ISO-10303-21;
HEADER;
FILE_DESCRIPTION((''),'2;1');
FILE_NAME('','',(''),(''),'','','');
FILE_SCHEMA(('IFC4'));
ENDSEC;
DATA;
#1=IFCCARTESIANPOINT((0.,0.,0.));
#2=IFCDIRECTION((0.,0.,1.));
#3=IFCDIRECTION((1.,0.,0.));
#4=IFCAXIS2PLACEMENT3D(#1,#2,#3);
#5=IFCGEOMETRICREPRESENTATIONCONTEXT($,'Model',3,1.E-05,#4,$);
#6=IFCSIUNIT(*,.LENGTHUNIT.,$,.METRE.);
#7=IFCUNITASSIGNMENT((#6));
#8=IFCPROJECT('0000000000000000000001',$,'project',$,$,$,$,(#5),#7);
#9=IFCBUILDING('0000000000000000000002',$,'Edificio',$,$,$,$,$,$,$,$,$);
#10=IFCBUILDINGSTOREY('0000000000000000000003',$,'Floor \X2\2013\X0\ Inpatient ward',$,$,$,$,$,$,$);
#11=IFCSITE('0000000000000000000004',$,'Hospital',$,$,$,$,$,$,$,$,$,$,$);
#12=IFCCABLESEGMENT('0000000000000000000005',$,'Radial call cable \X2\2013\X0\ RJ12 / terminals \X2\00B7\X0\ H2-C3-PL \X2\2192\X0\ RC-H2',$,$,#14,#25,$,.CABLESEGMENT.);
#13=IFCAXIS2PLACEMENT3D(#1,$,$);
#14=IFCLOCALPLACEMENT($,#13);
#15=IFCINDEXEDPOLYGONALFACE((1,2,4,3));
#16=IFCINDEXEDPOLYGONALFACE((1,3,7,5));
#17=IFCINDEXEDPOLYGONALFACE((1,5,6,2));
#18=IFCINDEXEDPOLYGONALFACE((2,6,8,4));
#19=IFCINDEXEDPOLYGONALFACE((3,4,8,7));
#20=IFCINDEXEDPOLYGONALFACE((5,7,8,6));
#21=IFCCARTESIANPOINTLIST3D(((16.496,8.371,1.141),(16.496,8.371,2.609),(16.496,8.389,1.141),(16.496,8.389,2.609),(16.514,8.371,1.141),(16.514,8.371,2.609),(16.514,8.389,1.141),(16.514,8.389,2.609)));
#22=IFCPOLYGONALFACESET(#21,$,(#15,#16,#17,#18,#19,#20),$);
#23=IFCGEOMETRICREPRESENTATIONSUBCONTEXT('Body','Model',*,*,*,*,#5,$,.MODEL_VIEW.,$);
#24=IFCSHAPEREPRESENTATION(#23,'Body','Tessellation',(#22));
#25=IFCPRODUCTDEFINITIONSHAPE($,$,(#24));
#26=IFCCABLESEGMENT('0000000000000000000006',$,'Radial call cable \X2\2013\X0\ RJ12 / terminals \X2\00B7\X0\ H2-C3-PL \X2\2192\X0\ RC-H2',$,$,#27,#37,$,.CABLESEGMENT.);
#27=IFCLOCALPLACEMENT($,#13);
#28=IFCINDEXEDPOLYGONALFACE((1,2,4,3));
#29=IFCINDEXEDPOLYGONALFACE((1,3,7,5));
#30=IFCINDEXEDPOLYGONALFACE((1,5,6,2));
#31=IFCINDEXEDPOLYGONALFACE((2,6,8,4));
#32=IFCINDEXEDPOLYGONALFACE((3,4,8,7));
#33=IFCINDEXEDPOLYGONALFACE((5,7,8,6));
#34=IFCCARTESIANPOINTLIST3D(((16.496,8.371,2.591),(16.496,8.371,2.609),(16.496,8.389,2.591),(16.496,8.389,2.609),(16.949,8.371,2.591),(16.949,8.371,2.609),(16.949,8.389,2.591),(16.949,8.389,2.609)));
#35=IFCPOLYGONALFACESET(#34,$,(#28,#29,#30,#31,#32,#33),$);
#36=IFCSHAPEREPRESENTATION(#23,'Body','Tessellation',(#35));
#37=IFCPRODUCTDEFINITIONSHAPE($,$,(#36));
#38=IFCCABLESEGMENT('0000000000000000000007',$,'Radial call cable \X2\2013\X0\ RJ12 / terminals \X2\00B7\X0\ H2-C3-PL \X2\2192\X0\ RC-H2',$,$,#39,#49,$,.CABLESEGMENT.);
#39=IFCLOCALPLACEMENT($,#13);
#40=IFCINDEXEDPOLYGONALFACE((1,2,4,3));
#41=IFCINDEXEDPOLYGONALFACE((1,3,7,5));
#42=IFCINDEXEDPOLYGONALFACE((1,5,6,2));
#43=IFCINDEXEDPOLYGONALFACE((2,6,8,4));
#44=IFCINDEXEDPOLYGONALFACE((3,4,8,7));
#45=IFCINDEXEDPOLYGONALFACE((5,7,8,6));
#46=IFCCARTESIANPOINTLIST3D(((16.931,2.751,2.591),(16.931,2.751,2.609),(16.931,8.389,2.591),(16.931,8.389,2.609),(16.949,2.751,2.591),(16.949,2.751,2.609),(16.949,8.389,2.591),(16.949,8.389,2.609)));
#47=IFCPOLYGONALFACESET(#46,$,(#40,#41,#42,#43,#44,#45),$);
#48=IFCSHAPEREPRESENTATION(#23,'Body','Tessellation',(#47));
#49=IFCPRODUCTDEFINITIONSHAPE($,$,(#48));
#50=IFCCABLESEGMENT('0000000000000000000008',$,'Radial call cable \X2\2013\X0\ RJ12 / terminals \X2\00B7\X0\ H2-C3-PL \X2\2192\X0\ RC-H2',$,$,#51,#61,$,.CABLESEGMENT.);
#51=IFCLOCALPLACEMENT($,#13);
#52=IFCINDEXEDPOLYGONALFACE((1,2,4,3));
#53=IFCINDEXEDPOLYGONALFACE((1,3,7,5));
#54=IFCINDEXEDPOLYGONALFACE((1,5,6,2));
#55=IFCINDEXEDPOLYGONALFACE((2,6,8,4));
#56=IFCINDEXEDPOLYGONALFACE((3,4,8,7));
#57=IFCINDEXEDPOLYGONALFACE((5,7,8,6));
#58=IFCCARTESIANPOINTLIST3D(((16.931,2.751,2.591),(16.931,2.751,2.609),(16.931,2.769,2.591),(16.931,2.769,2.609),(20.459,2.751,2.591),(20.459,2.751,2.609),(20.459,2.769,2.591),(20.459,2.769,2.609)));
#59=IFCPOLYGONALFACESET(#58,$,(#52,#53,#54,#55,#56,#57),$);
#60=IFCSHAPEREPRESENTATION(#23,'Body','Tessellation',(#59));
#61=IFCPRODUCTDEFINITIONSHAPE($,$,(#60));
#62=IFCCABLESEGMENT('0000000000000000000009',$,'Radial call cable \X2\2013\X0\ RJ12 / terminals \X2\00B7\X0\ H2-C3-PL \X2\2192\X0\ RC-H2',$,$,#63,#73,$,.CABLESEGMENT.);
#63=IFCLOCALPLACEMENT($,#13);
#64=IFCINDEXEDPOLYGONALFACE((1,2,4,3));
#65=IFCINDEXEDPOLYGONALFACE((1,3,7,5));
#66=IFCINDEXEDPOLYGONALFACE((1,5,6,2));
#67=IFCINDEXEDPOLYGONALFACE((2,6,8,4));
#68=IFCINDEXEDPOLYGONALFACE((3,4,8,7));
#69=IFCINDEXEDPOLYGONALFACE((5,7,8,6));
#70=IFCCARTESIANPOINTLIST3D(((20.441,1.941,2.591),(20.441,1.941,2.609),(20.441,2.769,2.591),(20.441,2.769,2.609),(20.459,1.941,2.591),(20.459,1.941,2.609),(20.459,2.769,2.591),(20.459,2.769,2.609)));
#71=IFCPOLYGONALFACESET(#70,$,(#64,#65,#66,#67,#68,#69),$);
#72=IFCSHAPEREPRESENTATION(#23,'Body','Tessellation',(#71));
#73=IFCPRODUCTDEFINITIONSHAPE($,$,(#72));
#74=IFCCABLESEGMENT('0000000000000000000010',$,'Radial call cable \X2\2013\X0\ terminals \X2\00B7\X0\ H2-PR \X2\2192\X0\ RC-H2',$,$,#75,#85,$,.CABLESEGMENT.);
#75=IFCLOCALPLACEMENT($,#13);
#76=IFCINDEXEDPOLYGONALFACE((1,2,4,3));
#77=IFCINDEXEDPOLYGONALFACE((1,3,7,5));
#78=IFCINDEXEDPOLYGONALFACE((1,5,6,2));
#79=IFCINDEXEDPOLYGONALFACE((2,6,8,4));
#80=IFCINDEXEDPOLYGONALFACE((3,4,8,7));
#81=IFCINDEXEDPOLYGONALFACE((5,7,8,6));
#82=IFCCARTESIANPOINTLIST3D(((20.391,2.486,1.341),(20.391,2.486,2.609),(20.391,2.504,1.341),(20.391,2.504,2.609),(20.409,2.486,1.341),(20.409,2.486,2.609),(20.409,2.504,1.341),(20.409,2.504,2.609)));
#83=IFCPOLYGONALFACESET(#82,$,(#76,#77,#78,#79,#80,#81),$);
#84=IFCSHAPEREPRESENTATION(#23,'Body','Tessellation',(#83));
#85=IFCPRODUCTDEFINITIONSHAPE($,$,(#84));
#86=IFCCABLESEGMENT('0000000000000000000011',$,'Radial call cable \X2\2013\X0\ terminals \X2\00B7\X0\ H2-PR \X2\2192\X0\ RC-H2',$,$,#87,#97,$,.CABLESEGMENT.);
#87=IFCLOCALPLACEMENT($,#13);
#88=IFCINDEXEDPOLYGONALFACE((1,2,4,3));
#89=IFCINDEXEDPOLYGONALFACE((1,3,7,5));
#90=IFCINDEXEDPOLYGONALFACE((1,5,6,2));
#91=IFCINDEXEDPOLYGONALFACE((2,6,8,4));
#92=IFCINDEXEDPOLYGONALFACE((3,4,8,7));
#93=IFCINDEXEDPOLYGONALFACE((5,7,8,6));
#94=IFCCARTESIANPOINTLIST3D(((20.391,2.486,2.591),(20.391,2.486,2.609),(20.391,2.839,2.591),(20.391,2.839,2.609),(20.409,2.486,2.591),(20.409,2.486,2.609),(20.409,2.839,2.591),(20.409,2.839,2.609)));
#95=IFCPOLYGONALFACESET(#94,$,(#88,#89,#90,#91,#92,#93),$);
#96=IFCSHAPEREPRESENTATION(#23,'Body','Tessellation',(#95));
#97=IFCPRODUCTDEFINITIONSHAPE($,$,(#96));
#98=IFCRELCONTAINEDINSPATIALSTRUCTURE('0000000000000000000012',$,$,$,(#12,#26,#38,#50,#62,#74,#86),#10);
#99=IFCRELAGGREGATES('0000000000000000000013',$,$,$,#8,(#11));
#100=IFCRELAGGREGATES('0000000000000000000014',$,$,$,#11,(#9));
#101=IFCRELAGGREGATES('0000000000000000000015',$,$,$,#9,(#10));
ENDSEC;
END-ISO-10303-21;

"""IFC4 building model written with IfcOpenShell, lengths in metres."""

from ifc_helpers import new_model, si_unit, frame, origin_with_axes, context, subcontext, project, spatial, line, indexed_curve, outline, extrude, element, save


model = new_model("IFC4")

# Units and contexts
model_context = context("Model", 3, precision=1e-05, world=origin_with_axes())
body_context = subcontext(model_context, "Body", "Model", "MODEL_VIEW")
ifc_project = project(units=[si_unit("LENGTHUNIT", "METRE")], contexts=[model_context])

# Site, building, storey
site = spatial("IfcSite", under=ifc_project, Name="Hospital")
building = spatial("IfcBuilding", under=site, Name="Edificio")
storey = spatial("IfcBuildingStorey", under=building, Name="Floor – Inpatient ward")

# Cable segments
element("IfcCableSegment", 1, inside=storey, Name="Radial call cable – RJ12 / terminals · H2-C3-PL → RC-H2", PredefinedType="CABLESEGMENT", context=body_context, shape_type="SweptSolid", body=[
    extrude(outline(indexed_curve([(0.0, 0.0), (0.018, 0.0), (0.018, 0.018), (0.0, 0.018)], segments=[line(1, 2, 3, 4, 1)])), frame((16.496, 8.371, 1.141), z_axis=(0.0, 0.0, 1.0), x_axis=(1.0, 0.0, 0.0)), (0.0, 0.0, 1.0), 1.468),
])
element("IfcCableSegment", 2, inside=storey, Name="Radial call cable – RJ12 / terminals · H2-C3-PL → RC-H2", PredefinedType="CABLESEGMENT", context=body_context, shape_type="SweptSolid", body=[
    extrude(outline(indexed_curve([(0.0, 0.0), (0.453, 0.0), (0.453, 0.018), (0.0, 0.018)], segments=[line(1, 2, 3, 4, 1)])), frame((16.496, 8.371, 2.591), z_axis=(0.0, 0.0, 1.0), x_axis=(1.0, 0.0, 0.0)), (0.0, 0.0, 1.0), 0.018),
])
element("IfcCableSegment", 3, inside=storey, Name="Radial call cable – RJ12 / terminals · H2-C3-PL → RC-H2", PredefinedType="CABLESEGMENT", context=body_context, shape_type="SweptSolid", body=[
    extrude(outline(indexed_curve([(0.0, 0.0), (0.018, 0.0), (0.018, 5.638), (0.0, 5.638)], segments=[line(1, 2, 3, 4, 1)])), frame((16.931, 2.751, 2.591), z_axis=(0.0, 0.0, 1.0), x_axis=(1.0, 0.0, 0.0)), (0.0, 0.0, 1.0), 0.018),
])
element("IfcCableSegment", 4, inside=storey, Name="Radial call cable – RJ12 / terminals · H2-C3-PL → RC-H2", PredefinedType="CABLESEGMENT", context=body_context, shape_type="SweptSolid", body=[
    extrude(outline(indexed_curve([(0.0, 0.0), (3.528, 0.0), (3.528, 0.018), (0.0, 0.018)], segments=[line(1, 2, 3, 4, 1)])), frame((16.931, 2.751, 2.591), z_axis=(0.0, 0.0, 1.0), x_axis=(1.0, 0.0, 0.0)), (0.0, 0.0, 1.0), 0.018),
])
element("IfcCableSegment", 5, inside=storey, Name="Radial call cable – RJ12 / terminals · H2-C3-PL → RC-H2", PredefinedType="CABLESEGMENT", context=body_context, shape_type="SweptSolid", body=[
    extrude(outline(indexed_curve([(0.0, 0.0), (0.018, 0.0), (0.018, 0.828), (0.0, 0.828)], segments=[line(1, 2, 3, 4, 1)])), frame((20.441, 1.941, 2.591), z_axis=(0.0, 0.0, 1.0), x_axis=(1.0, 0.0, 0.0)), (0.0, 0.0, 1.0), 0.018),
])
element("IfcCableSegment", 6, inside=storey, Name="Radial call cable – terminals · H2-PR → RC-H2", PredefinedType="CABLESEGMENT", context=body_context, shape_type="SweptSolid", body=[
    extrude(outline(indexed_curve([(0.0, 0.0), (0.018, 0.0), (0.018, 0.018), (0.0, 0.018)], segments=[line(1, 2, 3, 4, 1)])), frame((20.391, 2.486, 1.341), z_axis=(0.0, 0.0, 1.0), x_axis=(1.0, 0.0, 0.0)), (0.0, 0.0, 1.0), 1.268),
])
element("IfcCableSegment", 7, inside=storey, Name="Radial call cable – terminals · H2-PR → RC-H2", PredefinedType="CABLESEGMENT", context=body_context, shape_type="SweptSolid", body=[
    extrude(outline(indexed_curve([(0.0, 0.0), (0.018, 0.0), (0.018, 0.353), (0.0, 0.353)], segments=[line(1, 2, 3, 4, 1)])), frame((20.391, 2.486, 2.591), z_axis=(0.0, 0.0, 1.0), x_axis=(1.0, 0.0, 0.0)), (0.0, 0.0, 1.0), 0.018),
])

save(model, "model.ifc")
